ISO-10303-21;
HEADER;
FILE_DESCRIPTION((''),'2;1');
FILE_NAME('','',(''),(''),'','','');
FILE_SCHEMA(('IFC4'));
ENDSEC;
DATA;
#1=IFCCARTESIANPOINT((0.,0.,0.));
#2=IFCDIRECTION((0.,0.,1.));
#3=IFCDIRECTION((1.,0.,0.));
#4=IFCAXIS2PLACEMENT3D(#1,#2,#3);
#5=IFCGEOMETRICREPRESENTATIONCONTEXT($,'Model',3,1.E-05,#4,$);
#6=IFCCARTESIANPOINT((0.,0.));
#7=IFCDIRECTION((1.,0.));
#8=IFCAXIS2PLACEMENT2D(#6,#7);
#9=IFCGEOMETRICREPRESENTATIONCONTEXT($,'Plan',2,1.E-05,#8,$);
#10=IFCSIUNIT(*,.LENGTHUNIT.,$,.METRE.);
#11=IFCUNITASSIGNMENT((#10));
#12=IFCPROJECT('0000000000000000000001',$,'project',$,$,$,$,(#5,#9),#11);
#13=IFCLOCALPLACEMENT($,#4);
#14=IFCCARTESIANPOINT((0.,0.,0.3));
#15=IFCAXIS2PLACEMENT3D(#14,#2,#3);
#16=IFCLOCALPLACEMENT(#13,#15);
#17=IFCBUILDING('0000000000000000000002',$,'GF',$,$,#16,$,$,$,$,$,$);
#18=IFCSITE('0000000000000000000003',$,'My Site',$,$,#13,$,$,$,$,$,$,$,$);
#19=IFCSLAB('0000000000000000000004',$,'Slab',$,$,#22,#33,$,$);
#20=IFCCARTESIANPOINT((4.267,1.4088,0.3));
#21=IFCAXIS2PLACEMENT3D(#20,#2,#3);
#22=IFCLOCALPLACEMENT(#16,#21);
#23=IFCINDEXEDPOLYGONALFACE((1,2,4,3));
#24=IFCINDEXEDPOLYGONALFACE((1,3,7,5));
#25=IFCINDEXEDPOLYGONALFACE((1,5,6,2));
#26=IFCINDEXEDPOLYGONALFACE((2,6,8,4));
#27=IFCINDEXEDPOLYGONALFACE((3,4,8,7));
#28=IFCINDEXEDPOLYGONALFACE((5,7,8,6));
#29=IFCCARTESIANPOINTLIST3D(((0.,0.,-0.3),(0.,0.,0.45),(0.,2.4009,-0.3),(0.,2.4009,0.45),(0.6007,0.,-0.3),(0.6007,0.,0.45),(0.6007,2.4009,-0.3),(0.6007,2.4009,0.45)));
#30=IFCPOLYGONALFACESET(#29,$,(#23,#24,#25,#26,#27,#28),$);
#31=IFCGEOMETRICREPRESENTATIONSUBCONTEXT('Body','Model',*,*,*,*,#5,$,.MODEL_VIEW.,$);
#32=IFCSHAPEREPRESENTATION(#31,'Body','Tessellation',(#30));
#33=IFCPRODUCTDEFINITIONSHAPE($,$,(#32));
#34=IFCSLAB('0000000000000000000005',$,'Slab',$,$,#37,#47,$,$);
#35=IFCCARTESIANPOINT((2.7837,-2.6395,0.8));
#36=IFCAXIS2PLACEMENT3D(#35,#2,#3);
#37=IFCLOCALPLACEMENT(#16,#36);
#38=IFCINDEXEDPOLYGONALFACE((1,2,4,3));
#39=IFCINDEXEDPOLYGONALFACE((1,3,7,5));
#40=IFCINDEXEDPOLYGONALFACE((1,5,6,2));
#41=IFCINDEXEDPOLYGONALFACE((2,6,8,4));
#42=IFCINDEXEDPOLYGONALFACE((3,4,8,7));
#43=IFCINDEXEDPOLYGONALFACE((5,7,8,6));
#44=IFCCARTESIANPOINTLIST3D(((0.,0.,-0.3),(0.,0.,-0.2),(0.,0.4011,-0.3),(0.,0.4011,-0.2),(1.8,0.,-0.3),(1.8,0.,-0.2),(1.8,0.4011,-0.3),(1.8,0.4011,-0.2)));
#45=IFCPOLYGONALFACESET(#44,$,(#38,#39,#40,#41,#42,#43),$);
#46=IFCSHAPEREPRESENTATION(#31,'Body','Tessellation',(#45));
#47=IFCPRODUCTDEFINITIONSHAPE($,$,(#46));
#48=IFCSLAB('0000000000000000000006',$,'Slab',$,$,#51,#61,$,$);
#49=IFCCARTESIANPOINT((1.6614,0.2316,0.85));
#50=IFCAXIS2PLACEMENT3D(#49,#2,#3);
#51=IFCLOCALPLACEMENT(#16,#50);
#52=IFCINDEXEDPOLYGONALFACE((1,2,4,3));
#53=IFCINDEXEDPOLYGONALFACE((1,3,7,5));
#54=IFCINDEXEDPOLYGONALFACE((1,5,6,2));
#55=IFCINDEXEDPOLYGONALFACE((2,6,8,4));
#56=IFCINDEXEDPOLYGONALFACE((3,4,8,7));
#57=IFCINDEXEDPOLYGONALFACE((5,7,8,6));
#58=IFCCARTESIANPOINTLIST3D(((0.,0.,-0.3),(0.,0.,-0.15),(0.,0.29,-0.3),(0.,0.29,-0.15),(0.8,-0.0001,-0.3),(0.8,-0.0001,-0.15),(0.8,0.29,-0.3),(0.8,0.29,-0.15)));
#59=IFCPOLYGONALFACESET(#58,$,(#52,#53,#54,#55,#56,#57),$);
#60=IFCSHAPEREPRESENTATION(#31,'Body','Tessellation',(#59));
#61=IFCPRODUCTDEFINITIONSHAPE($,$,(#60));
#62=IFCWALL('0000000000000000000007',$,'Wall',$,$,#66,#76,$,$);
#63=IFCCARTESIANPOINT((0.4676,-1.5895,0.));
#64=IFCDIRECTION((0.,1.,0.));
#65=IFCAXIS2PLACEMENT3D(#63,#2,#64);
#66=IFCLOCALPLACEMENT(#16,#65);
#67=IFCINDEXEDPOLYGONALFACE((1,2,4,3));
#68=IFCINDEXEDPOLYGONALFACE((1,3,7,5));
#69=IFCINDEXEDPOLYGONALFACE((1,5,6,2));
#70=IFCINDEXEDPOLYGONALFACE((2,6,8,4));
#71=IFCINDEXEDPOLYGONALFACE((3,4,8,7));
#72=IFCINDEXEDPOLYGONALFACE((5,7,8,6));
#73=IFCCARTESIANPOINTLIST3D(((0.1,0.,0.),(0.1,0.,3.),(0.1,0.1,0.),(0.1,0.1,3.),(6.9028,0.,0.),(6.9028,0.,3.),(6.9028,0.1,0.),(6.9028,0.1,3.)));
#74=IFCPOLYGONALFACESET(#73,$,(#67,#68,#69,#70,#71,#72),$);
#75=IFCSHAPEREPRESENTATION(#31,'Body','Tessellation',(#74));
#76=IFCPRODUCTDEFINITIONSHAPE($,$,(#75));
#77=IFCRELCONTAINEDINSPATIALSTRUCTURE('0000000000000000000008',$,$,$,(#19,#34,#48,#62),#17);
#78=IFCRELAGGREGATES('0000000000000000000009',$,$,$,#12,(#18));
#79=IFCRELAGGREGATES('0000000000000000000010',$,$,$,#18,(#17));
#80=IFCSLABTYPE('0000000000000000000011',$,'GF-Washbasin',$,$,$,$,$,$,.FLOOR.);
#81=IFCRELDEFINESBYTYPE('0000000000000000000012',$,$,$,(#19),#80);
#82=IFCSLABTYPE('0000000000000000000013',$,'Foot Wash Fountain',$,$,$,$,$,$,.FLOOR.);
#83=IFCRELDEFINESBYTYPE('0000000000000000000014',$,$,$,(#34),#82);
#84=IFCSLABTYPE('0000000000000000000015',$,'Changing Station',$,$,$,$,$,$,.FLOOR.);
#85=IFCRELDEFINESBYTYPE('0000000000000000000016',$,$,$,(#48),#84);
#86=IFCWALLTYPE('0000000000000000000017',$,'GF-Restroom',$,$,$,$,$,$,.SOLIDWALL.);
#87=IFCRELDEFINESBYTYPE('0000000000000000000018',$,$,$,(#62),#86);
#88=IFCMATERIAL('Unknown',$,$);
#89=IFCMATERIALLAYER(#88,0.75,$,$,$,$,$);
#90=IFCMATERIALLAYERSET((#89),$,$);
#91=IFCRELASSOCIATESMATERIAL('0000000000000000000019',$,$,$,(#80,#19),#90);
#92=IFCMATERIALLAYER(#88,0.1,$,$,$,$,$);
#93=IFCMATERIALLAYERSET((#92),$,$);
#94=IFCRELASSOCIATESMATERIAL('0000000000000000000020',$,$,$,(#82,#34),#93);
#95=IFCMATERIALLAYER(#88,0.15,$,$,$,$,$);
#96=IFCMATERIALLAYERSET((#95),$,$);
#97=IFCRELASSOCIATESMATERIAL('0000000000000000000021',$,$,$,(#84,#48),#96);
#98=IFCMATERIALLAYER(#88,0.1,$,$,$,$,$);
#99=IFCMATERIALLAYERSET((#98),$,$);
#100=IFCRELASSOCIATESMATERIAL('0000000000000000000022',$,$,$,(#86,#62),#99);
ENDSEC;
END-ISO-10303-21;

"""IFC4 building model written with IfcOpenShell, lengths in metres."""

from ifc_helpers import new_model, si_unit, frame, origin_with_axes, origin_2d_with_axis, place, context, subcontext, project, spatial, line, indexed_curve, outline, extrude, material, layer, layer_set, layer_usage, type_object, element, save


model = new_model("IFC4")

# Units and contexts
model_context = context("Model", 3, precision=1e-05, world=origin_with_axes())
plan_context = context("Plan", 2, precision=1e-05, world=origin_2d_with_axis())
body_context_1 = subcontext(model_context, "Body", "Model", "MODEL_VIEW")
ifc_project = project(units=[si_unit("LENGTHUNIT", "METRE")], contexts=[model_context, plan_context])

# Site, building
site_placement = place(None, origin_with_axes())
site = spatial("IfcSite", under=ifc_project, at=site_placement, Name="My Site")
building_placement = place(site_placement, frame((0.0, 0.0, 0.3), z_axis=(0.0, 0.0, 1.0), x_axis=(1.0, 0.0, 0.0)))
building = spatial("IfcBuilding", under=site, at=building_placement, Name="GF")

# Shared definitions
ifc_material = material(Name="Unknown")

# Slabs
ifc_layer_1 = layer(ifc_material, 0.75)
ifc_layer_set_1 = layer_set([ifc_layer_1])
ifc_layer_usage_1 = layer_usage(ifc_layer_set_1, "AXIS3", "POSITIVE", -0.3)
slab_type_1 = type_object("IfcSlabType", Name="GF-Washbasin", PredefinedType="FLOOR", material=ifc_layer_set_1)
slab_1_placement = place(building_placement, frame((4.267, 1.4088, 0.3), z_axis=(0.0, 0.0, 1.0), x_axis=(1.0, 0.0, 0.0)))
element("IfcSlab", 1, at=slab_1_placement, inside=building, type_object=slab_type_1, material=ifc_layer_usage_1, Name="Slab", context=body_context_1, shape_type="SweptSolid", body=[
    extrude(outline(indexed_curve([(0.0, 0.0), (0.6007, 0.0), (0.6007, 2.4009), (0.0, 2.4009), (0.0, 0.0)])), frame((0.0, 0.0, -0.3), z_axis=(0.0, 0.0, 1.0), x_axis=(1.0, 0.0, 0.0)), (0.0, 0.0, 1.0), 0.75),
])
ifc_layer_2 = layer(ifc_material, 0.1)
ifc_layer_set_2 = layer_set([ifc_layer_2])
ifc_layer_usage_2 = layer_usage(ifc_layer_set_2, "AXIS3", "POSITIVE", -0.3)
slab_type_2 = type_object("IfcSlabType", Name="Foot Wash Fountain", PredefinedType="FLOOR", material=ifc_layer_set_2)
slab_2_placement = place(building_placement, frame((2.7837, -2.6395, 0.8), z_axis=(0.0, 0.0, 1.0), x_axis=(1.0, 0.0, 0.0)))
element("IfcSlab", 2, at=slab_2_placement, inside=building, type_object=slab_type_2, material=ifc_layer_usage_2, Name="Slab", context=body_context_1, shape_type="SweptSolid", body=[
    extrude(outline(indexed_curve([(0.0, 0.0), (0.0, 0.4011), (1.8, 0.4011), (1.8, 0.0), (0.0, 0.0)])), frame((0.0, 0.0, -0.3), z_axis=(0.0, 0.0, 1.0), x_axis=(1.0, 0.0, 0.0)), (0.0, 0.0, 1.0), 0.1),
])
ifc_layer_3 = layer(ifc_material, 0.15)
ifc_layer_set_3 = layer_set([ifc_layer_3])
ifc_layer_usage_3 = layer_usage(ifc_layer_set_3, "AXIS3", "POSITIVE", -0.3)
slab_type_3 = type_object("IfcSlabType", Name="Changing Station", PredefinedType="FLOOR", material=ifc_layer_set_3)
slab_3_placement = place(building_placement, frame((1.6614, 0.2316, 0.85), z_axis=(0.0, 0.0, 1.0), x_axis=(1.0, 0.0, 0.0)))
element("IfcSlab", 3, at=slab_3_placement, inside=building, type_object=slab_type_3, material=ifc_layer_usage_3, Name="Slab", context=body_context_1, shape_type="SweptSolid", body=[
    extrude(outline(indexed_curve([(0.0, 0.0), (0.0, 0.29), (0.8, 0.29), (0.8, -0.0001), (0.0, 0.0)])), frame((0.0, 0.0, -0.3), z_axis=(0.0, 0.0, 1.0), x_axis=(1.0, 0.0, 0.0)), (0.0, 0.0, 1.0), 0.15),
])

# Shared definitions
ifc_layer_4 = layer(ifc_material, 0.1)
ifc_layer_set_4 = layer_set([ifc_layer_4])
wall_type_1 = type_object("IfcWallType", Name="GF-Restroom", PredefinedType="SOLIDWALL", material=ifc_layer_set_4)

# Wall
ifc_layer_usage_4 = layer_usage(ifc_layer_set_4, "AXIS2", "POSITIVE", 0.0)
wall_1_placement = place(building_placement, frame((0.4676, -1.5895, 0.0), z_axis=(0.0, 0.0, 1.0), x_axis=(0.0, 1.0, 0.0)))
element("IfcWall", 4, at=wall_1_placement, inside=building, type_object=wall_type_1, material=ifc_layer_usage_4, Name="Wall", context=body_context_1, shape_type="SweptSolid", body=[
    extrude(outline(indexed_curve([(0.1, 0.0), (0.1, 0.1), (6.9028, 0.1), (6.9028, 0.0)], segments=[line(1, 2, 3, 4, 1)])), origin_with_axes(), (0.0, 0.0, 1.0), 3.0),
])

save(model, "model.ifc")
